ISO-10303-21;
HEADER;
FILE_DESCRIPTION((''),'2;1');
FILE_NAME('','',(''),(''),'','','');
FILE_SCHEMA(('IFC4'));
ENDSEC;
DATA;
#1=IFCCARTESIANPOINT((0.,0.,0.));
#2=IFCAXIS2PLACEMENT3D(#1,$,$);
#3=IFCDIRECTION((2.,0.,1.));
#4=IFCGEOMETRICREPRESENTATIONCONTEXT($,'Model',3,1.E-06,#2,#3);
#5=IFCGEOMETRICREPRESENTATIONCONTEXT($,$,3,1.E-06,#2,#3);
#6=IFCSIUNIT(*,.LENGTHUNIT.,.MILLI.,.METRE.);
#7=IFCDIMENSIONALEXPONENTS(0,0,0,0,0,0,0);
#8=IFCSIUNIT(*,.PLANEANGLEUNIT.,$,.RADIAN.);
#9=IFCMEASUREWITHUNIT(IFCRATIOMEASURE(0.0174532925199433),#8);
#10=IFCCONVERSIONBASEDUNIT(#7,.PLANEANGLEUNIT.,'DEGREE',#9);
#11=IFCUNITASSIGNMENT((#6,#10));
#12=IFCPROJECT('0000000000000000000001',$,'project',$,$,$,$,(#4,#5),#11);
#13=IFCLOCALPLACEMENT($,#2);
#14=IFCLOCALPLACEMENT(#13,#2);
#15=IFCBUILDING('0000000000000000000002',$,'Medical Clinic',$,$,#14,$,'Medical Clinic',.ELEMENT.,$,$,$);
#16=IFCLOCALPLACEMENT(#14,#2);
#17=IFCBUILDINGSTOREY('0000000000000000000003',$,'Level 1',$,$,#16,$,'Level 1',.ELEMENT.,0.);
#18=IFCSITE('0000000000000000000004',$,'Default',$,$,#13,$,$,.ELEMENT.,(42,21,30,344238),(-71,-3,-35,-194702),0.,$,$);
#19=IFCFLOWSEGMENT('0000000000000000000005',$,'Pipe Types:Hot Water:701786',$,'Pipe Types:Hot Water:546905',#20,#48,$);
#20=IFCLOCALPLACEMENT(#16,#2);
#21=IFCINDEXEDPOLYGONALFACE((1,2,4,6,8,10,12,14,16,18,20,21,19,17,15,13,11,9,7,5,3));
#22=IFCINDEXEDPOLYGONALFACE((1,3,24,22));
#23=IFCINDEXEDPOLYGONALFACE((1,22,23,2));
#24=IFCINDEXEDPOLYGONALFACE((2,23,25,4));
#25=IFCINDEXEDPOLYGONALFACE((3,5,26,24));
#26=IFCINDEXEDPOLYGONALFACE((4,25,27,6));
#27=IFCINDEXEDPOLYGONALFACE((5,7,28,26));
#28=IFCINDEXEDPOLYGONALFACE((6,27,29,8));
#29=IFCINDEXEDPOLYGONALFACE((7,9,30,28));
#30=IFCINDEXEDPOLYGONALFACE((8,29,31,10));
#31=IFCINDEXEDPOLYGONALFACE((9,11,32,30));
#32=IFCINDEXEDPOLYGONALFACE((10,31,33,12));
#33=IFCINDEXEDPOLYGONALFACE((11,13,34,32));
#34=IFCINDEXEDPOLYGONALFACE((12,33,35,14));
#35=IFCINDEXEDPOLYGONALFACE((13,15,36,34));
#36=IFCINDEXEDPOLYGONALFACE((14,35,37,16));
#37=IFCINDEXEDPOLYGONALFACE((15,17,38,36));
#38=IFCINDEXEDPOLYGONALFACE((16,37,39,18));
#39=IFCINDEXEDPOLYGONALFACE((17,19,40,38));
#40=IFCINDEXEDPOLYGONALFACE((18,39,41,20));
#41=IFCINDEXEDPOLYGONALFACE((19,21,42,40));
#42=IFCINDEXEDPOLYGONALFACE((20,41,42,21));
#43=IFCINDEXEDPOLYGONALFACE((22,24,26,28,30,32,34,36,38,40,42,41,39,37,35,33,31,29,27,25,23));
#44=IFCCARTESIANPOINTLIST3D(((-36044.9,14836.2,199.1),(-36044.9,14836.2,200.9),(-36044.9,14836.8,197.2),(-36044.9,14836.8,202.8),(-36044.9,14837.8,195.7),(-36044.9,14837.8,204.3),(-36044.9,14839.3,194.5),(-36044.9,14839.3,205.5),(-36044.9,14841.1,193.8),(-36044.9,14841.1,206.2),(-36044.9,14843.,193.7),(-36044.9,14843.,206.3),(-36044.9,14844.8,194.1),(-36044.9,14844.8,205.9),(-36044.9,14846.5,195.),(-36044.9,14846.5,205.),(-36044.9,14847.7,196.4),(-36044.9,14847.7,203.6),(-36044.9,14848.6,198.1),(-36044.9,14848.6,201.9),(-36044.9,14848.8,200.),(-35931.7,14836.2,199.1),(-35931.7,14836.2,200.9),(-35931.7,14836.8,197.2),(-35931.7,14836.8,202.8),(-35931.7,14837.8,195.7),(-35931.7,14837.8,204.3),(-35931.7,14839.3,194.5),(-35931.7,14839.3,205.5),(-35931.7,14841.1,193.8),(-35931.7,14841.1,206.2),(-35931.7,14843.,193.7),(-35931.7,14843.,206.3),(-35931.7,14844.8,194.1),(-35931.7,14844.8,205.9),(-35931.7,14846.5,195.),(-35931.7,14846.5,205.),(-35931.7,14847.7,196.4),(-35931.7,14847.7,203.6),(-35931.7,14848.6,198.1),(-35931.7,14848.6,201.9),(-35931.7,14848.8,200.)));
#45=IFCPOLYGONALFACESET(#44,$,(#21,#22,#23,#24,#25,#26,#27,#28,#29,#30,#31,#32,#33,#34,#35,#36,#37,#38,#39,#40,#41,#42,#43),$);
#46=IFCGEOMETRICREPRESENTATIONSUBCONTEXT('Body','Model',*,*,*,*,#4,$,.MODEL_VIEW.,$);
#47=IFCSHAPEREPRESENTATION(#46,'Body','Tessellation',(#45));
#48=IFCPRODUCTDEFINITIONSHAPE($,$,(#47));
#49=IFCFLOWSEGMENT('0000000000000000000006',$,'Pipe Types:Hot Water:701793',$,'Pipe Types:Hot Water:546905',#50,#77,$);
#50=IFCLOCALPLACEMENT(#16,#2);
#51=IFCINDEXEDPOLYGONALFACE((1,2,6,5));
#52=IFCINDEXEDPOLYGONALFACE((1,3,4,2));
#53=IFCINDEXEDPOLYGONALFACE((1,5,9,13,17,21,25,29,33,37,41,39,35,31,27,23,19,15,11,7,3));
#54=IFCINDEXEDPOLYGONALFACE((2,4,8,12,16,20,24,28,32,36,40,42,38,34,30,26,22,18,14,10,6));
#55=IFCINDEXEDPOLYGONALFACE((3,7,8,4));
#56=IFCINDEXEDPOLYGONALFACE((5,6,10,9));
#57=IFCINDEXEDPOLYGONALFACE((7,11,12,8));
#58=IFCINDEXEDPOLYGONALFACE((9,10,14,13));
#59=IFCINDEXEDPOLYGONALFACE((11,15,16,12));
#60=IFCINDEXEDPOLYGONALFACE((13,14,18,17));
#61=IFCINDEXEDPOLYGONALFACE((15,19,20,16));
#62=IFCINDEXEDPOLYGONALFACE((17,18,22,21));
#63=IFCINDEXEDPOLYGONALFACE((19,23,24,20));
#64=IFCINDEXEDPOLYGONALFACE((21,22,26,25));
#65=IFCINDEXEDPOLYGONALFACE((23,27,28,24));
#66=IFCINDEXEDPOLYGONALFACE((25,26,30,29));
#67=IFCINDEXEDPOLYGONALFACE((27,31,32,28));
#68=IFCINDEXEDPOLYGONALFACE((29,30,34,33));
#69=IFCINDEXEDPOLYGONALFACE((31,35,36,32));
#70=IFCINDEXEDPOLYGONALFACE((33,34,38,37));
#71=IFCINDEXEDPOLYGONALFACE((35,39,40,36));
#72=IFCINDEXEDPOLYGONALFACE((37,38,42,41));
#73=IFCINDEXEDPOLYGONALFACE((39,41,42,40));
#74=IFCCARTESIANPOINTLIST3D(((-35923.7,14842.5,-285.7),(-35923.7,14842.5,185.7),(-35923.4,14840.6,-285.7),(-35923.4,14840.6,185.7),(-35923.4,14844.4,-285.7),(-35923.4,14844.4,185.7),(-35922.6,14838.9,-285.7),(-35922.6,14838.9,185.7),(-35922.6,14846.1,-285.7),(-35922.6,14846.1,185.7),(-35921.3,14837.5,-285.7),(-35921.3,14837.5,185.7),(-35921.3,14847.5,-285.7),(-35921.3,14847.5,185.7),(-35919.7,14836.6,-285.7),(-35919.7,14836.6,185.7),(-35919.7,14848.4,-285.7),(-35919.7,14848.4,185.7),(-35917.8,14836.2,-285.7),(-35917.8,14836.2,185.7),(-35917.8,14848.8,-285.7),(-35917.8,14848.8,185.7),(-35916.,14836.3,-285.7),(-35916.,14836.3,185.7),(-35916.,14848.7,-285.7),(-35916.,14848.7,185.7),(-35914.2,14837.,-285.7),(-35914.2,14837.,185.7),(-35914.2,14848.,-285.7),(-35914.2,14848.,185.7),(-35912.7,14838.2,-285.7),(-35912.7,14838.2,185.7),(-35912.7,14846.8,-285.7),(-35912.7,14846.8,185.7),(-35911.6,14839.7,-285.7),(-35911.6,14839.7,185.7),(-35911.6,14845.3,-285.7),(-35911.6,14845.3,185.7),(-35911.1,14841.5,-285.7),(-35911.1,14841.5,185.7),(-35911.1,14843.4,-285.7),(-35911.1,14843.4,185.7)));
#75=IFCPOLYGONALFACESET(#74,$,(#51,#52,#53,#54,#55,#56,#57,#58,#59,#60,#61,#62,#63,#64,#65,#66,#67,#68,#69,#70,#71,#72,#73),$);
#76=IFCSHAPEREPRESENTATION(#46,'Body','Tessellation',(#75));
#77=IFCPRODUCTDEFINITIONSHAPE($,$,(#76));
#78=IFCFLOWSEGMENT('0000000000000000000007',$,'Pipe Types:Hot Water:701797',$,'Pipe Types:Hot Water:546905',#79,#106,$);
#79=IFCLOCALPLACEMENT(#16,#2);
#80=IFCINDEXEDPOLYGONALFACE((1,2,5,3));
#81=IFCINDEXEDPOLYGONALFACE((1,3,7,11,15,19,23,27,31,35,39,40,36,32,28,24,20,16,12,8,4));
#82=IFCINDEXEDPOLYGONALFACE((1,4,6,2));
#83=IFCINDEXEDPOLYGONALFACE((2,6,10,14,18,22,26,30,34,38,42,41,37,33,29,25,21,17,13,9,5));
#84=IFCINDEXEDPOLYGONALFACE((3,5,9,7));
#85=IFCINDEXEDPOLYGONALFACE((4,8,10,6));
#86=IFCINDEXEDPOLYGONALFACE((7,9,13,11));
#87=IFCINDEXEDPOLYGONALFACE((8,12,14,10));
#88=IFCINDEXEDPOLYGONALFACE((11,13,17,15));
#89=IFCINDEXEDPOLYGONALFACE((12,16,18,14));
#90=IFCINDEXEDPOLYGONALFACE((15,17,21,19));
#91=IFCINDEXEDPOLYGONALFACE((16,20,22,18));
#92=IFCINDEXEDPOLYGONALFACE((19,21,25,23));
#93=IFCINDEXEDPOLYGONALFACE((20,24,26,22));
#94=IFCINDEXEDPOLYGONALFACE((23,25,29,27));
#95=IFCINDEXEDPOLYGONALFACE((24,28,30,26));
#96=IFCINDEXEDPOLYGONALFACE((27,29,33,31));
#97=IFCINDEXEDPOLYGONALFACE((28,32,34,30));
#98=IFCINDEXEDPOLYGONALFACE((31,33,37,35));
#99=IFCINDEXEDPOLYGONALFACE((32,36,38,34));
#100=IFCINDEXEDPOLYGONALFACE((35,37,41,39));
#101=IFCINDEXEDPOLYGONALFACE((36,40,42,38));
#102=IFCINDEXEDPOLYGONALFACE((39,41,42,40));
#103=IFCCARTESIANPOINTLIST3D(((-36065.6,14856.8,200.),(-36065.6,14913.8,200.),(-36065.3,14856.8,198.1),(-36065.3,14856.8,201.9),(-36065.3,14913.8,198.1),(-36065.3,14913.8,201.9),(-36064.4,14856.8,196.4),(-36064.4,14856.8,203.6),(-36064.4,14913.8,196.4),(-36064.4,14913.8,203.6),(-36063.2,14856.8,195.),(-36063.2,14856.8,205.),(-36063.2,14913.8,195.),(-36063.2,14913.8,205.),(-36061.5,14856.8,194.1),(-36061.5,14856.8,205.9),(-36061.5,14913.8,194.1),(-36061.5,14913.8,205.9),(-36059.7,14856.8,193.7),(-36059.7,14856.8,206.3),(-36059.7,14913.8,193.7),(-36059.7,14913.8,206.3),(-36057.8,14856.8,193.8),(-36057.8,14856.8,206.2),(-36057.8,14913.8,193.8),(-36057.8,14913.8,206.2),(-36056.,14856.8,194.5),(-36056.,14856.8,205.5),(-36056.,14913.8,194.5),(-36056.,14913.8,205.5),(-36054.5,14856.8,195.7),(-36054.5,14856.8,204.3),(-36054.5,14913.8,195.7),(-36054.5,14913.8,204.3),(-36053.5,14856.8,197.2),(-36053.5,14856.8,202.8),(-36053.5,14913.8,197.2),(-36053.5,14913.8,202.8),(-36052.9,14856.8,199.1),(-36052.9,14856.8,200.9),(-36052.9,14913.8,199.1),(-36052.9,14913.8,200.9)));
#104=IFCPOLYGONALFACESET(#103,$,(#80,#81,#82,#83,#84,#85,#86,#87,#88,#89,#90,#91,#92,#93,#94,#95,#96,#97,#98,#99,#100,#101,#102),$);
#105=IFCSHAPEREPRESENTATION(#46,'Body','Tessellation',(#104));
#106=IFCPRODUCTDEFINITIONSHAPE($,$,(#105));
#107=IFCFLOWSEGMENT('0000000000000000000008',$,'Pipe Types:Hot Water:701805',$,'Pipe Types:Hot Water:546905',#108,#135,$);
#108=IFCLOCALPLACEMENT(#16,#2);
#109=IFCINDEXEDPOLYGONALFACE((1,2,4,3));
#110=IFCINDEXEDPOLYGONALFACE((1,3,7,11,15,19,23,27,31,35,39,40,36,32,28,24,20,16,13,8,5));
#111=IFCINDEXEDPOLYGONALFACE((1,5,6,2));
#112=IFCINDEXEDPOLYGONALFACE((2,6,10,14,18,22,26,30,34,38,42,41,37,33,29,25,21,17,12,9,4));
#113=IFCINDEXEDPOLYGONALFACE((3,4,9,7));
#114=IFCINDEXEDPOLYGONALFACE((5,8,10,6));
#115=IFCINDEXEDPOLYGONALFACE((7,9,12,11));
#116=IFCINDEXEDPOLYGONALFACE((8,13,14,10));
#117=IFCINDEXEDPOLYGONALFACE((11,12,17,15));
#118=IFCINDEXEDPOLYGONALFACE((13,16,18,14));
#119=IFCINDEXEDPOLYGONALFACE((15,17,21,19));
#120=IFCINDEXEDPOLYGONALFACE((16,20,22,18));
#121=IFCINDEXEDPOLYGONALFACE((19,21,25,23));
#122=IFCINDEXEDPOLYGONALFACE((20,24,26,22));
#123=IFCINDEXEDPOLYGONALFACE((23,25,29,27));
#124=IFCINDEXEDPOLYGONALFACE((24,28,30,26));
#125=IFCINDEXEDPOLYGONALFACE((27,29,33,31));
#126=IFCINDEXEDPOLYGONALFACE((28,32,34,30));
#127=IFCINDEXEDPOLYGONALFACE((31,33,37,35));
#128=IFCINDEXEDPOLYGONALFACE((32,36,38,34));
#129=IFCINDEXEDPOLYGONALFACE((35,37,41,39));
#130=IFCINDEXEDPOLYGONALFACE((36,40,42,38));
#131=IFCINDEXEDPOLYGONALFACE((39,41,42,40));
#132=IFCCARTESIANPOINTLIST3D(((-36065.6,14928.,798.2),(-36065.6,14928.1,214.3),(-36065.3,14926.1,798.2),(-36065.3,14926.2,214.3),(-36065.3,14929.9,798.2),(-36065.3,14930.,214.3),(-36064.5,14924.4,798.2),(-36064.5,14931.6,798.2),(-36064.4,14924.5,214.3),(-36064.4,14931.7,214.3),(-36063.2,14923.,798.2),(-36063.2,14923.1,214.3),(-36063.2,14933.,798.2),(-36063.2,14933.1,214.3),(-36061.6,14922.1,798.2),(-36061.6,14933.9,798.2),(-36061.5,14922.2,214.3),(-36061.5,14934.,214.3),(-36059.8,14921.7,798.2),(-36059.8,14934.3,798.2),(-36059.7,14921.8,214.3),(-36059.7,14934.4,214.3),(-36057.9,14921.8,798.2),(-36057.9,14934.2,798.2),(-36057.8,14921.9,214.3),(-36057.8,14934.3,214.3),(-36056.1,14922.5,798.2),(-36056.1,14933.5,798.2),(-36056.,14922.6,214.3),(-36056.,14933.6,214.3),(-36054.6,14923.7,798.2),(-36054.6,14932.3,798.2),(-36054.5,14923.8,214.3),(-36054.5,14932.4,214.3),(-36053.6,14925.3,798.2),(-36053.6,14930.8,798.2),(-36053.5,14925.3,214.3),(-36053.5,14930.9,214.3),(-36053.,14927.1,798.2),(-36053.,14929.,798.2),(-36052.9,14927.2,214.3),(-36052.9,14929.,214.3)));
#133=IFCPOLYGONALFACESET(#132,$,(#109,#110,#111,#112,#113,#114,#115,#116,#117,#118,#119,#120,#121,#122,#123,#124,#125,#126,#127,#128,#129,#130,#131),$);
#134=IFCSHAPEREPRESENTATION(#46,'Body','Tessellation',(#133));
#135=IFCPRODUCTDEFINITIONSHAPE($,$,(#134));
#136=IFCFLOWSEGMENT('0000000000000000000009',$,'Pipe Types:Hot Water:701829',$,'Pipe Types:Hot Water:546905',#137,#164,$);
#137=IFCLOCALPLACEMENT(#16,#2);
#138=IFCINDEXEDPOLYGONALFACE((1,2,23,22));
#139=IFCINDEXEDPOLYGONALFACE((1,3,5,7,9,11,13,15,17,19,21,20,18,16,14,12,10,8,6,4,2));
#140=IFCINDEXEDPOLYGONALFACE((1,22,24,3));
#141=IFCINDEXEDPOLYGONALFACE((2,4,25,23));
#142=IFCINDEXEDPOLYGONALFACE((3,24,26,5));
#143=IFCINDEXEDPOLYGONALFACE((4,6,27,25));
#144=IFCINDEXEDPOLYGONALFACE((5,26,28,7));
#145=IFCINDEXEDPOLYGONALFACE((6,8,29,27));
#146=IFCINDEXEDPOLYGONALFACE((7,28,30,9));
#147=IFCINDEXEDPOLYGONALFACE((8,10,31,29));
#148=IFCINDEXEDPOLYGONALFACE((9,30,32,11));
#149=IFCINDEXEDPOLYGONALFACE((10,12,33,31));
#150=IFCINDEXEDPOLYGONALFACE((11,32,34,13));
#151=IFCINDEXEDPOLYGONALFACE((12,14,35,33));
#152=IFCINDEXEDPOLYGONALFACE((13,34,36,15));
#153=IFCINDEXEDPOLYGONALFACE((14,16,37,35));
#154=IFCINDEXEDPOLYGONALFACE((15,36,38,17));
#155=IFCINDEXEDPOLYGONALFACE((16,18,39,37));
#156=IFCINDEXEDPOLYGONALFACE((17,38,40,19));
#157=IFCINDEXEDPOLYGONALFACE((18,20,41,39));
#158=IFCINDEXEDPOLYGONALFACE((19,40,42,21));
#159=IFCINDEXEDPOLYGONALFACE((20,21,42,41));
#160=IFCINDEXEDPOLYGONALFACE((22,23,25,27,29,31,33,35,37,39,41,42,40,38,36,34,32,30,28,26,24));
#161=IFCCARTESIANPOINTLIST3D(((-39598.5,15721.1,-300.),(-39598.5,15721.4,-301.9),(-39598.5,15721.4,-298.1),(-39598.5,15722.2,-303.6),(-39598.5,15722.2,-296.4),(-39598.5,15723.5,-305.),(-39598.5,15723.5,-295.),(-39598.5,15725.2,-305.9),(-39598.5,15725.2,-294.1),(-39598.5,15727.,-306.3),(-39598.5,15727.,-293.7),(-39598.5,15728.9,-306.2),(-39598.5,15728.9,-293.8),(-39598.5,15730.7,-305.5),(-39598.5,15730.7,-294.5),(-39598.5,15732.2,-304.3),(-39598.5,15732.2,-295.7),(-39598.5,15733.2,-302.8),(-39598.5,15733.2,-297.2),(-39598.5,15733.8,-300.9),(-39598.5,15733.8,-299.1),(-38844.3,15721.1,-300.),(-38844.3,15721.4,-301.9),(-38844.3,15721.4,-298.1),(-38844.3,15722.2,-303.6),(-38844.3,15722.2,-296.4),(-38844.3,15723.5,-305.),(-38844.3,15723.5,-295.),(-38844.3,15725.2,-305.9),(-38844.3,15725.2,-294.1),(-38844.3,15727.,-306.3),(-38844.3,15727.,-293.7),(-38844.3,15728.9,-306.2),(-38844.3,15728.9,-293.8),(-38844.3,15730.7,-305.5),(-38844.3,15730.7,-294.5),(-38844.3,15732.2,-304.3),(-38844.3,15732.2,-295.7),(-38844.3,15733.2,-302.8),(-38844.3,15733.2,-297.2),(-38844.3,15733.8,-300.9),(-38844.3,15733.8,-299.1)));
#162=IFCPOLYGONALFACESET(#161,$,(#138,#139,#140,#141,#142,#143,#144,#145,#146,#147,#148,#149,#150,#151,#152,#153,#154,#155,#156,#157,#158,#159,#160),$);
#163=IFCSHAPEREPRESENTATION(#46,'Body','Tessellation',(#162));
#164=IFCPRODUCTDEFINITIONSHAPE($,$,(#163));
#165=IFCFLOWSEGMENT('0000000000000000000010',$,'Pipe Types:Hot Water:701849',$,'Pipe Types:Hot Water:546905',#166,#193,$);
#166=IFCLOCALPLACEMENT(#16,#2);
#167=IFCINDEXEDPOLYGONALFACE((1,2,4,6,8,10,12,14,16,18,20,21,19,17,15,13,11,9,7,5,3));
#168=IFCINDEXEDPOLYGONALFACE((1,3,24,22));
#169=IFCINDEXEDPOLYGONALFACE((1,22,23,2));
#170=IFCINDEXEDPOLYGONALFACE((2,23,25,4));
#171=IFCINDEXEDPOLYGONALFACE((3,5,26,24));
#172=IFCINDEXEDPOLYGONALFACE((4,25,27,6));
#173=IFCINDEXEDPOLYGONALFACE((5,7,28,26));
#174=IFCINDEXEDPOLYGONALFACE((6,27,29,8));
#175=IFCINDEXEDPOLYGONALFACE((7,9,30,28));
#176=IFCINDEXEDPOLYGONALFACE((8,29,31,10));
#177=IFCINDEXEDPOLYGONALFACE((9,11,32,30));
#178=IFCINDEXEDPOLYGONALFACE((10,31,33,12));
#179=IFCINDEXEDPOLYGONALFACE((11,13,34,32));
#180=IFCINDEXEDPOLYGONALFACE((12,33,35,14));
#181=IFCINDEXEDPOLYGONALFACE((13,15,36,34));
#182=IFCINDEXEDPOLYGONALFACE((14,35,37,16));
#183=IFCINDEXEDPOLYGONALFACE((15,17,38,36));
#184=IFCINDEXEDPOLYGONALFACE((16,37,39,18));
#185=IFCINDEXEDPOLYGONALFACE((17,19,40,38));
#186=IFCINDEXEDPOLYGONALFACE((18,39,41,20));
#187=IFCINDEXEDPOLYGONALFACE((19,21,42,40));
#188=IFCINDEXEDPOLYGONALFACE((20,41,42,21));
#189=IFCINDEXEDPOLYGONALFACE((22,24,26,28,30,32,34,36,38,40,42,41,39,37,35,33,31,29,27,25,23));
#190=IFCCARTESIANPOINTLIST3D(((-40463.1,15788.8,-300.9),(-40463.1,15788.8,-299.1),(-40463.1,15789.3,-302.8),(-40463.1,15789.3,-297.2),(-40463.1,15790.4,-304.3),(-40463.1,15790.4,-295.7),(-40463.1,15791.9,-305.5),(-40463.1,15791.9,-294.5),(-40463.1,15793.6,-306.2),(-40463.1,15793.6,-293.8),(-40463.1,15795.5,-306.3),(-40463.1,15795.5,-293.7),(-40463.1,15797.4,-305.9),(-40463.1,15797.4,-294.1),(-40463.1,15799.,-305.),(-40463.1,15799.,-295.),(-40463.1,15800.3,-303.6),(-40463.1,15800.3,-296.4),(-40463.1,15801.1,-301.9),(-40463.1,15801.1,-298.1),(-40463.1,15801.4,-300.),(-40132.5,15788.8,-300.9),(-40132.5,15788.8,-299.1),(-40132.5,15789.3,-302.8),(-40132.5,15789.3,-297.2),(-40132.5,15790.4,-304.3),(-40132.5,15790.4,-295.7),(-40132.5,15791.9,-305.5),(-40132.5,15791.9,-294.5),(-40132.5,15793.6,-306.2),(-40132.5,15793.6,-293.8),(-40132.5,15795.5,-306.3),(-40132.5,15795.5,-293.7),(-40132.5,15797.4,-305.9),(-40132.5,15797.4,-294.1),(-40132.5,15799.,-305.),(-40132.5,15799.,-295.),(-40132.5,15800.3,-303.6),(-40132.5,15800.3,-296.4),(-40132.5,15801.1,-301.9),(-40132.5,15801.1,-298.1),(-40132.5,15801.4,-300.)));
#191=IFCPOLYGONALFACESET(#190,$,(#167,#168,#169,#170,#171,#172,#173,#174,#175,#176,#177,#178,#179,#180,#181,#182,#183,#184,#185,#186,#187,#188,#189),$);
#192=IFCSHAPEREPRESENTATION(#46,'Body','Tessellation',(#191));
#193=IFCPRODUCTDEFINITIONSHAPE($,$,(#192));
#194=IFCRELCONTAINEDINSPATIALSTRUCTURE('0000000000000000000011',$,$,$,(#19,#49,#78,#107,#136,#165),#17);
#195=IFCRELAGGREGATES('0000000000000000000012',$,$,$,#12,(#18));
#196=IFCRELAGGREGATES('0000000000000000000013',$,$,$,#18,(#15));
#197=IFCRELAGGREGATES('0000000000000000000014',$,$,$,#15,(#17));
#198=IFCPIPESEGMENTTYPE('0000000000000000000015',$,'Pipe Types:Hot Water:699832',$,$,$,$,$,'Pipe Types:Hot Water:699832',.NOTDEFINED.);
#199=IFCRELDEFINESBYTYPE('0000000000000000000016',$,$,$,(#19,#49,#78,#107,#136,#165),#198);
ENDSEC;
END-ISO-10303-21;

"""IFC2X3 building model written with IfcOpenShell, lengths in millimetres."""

from ifc_helpers import new_model, entity, si_unit, converted_unit, direction, frame, frame_2d, origin, place, context, subcontext, project, spatial, circle, extrude, type_object, element, save


model = new_model("IFC2X3")

# Units and contexts
model_context = context("Model", 3, precision=1e-06, world=origin(), true_north=direction((2.0, 0.0, 1.0)))
context_of_model = context(None, 3, precision=1e-06, world=origin(), true_north=direction((2.0, 0.0, 1.0)))
body_context = subcontext(model_context, "Body", "Model", "MODEL_VIEW")
ifc_project = project(units=[si_unit("LENGTHUNIT", "METRE", prefix="MILLI"), converted_unit("PLANEANGLEUNIT", "DEGREE", entity("IfcRatioMeasure", 0.0174532925199433), si_unit("PLANEANGLEUNIT", "RADIAN"), dimensions=[0, 0, 0, 0, 0, 0, 0])], contexts=[model_context, context_of_model])

# Site, building, storey
site_placement = place(None, origin())
site = spatial("IfcSite", under=ifc_project, at=site_placement, Name="Default", CompositionType="ELEMENT", RefLatitude=(42, 21, 30, 344238), RefLongitude=(-71, -3, -35, -194702), RefElevation=0.0)
building_placement = place(site_placement, origin())
building = spatial("IfcBuilding", under=site, at=building_placement, Name="Medical Clinic", LongName="Medical Clinic", CompositionType="ELEMENT")
storey_placement = place(building_placement, origin())
storey = spatial("IfcBuildingStorey", under=building, at=storey_placement, Name="Level 1", LongName="Level 1", CompositionType="ELEMENT", Elevation=0.0)

# Flow segments
pipe_segment_type_1 = type_object("IfcPipeSegmentType", Name="Pipe Types:Hot Water:699832", ElementType="Pipe Types:Hot Water:699832", PredefinedType="NOTDEFINED")
flow_segment_1_placement = place(storey_placement, origin())
element("IfcFlowSegment", 1, at=flow_segment_1_placement, inside=storey, type_object=pipe_segment_type_1, Name="Pipe Types:Hot Water:701786", ObjectType="Pipe Types:Hot Water:546905", context=body_context, shape_type="SweptSolid", body=[
    extrude(circle(Radius=6.3, at=frame_2d((0.0, 0.0), x_axis=(1.0, 0.0))), frame((-36044.9, 14842.5, 200.0), z_axis=(1.0, 0.0, 0.0), x_axis=(0.0, 1.0, 0.0)), (0.0, 0.0, 1.0), 113.3),
])
flow_segment_2_placement = place(storey_placement, origin())
element("IfcFlowSegment", 2, at=flow_segment_2_placement, inside=storey, type_object=pipe_segment_type_1, Name="Pipe Types:Hot Water:701793", ObjectType="Pipe Types:Hot Water:546905", context=body_context, shape_type="SweptSolid", body=[
    extrude(circle(Radius=6.3, at=frame_2d((0.0, 0.0), x_axis=(1.0, 0.0))), frame((-35917.4, 14842.5, -285.7), z_axis=(0.0, 0.0, 1.0), x_axis=(-1.0, 0.0, 0.0)), (0.0, 0.0, 1.0), 471.4),
])
flow_segment_3_placement = place(storey_placement, origin())
element("IfcFlowSegment", 3, at=flow_segment_3_placement, inside=storey, type_object=pipe_segment_type_1, Name="Pipe Types:Hot Water:701797", ObjectType="Pipe Types:Hot Water:546905", context=body_context, shape_type="SweptSolid", body=[
    extrude(circle(Radius=6.3, at=frame_2d((0.0, 0.0), x_axis=(1.0, 0.0))), frame((-36059.2, 14856.8, 200.0), z_axis=(0.0, 1.0, 0.0), x_axis=(-1.0, 0.0, 0.0)), (0.0, 0.0, 1.0), 57.0),
])
flow_segment_4_placement = place(storey_placement, origin())
element("IfcFlowSegment", 4, at=flow_segment_4_placement, inside=storey, type_object=pipe_segment_type_1, Name="Pipe Types:Hot Water:701805", ObjectType="Pipe Types:Hot Water:546905", context=body_context, shape_type="SweptSolid", body=[
    extrude(circle(Radius=6.3, at=frame_2d((0.0, 0.0), x_axis=(1.0, 0.0))), frame((-36059.2, 14928.1, 214.3), z_axis=(-0.000126, -0.000144, 1.0), x_axis=(-1.0, 0.0, -0.000126)), (0.0, 0.0, 1.0), 583.9),
])
flow_segment_5_placement = place(storey_placement, origin())
element("IfcFlowSegment", 5, at=flow_segment_5_placement, inside=storey, type_object=pipe_segment_type_1, Name="Pipe Types:Hot Water:701829", ObjectType="Pipe Types:Hot Water:546905", context=body_context, shape_type="SweptSolid", body=[
    extrude(circle(Radius=6.3, at=frame_2d((0.0, 0.0), x_axis=(1.0, 0.0))), frame((-39598.5, 15727.5, -300.0), z_axis=(1.0, 0.0, 0.0), x_axis=(0.0, -1.0, 0.0)), (0.0, 0.0, 1.0), 754.2),
])
flow_segment_6_placement = place(storey_placement, origin())
element("IfcFlowSegment", 6, at=flow_segment_6_placement, inside=storey, type_object=pipe_segment_type_1, Name="Pipe Types:Hot Water:701849", ObjectType="Pipe Types:Hot Water:546905", context=body_context, shape_type="SweptSolid", body=[
    extrude(circle(Radius=6.3, at=frame_2d((0.0, 0.0), x_axis=(1.0, 0.0))), frame((-40463.1, 15795.1, -300.0), z_axis=(1.0, 0.0, 0.0), x_axis=(0.0, 1.0, 0.0)), (0.0, 0.0, 1.0), 330.6),
])

save(model, "model.ifc")
